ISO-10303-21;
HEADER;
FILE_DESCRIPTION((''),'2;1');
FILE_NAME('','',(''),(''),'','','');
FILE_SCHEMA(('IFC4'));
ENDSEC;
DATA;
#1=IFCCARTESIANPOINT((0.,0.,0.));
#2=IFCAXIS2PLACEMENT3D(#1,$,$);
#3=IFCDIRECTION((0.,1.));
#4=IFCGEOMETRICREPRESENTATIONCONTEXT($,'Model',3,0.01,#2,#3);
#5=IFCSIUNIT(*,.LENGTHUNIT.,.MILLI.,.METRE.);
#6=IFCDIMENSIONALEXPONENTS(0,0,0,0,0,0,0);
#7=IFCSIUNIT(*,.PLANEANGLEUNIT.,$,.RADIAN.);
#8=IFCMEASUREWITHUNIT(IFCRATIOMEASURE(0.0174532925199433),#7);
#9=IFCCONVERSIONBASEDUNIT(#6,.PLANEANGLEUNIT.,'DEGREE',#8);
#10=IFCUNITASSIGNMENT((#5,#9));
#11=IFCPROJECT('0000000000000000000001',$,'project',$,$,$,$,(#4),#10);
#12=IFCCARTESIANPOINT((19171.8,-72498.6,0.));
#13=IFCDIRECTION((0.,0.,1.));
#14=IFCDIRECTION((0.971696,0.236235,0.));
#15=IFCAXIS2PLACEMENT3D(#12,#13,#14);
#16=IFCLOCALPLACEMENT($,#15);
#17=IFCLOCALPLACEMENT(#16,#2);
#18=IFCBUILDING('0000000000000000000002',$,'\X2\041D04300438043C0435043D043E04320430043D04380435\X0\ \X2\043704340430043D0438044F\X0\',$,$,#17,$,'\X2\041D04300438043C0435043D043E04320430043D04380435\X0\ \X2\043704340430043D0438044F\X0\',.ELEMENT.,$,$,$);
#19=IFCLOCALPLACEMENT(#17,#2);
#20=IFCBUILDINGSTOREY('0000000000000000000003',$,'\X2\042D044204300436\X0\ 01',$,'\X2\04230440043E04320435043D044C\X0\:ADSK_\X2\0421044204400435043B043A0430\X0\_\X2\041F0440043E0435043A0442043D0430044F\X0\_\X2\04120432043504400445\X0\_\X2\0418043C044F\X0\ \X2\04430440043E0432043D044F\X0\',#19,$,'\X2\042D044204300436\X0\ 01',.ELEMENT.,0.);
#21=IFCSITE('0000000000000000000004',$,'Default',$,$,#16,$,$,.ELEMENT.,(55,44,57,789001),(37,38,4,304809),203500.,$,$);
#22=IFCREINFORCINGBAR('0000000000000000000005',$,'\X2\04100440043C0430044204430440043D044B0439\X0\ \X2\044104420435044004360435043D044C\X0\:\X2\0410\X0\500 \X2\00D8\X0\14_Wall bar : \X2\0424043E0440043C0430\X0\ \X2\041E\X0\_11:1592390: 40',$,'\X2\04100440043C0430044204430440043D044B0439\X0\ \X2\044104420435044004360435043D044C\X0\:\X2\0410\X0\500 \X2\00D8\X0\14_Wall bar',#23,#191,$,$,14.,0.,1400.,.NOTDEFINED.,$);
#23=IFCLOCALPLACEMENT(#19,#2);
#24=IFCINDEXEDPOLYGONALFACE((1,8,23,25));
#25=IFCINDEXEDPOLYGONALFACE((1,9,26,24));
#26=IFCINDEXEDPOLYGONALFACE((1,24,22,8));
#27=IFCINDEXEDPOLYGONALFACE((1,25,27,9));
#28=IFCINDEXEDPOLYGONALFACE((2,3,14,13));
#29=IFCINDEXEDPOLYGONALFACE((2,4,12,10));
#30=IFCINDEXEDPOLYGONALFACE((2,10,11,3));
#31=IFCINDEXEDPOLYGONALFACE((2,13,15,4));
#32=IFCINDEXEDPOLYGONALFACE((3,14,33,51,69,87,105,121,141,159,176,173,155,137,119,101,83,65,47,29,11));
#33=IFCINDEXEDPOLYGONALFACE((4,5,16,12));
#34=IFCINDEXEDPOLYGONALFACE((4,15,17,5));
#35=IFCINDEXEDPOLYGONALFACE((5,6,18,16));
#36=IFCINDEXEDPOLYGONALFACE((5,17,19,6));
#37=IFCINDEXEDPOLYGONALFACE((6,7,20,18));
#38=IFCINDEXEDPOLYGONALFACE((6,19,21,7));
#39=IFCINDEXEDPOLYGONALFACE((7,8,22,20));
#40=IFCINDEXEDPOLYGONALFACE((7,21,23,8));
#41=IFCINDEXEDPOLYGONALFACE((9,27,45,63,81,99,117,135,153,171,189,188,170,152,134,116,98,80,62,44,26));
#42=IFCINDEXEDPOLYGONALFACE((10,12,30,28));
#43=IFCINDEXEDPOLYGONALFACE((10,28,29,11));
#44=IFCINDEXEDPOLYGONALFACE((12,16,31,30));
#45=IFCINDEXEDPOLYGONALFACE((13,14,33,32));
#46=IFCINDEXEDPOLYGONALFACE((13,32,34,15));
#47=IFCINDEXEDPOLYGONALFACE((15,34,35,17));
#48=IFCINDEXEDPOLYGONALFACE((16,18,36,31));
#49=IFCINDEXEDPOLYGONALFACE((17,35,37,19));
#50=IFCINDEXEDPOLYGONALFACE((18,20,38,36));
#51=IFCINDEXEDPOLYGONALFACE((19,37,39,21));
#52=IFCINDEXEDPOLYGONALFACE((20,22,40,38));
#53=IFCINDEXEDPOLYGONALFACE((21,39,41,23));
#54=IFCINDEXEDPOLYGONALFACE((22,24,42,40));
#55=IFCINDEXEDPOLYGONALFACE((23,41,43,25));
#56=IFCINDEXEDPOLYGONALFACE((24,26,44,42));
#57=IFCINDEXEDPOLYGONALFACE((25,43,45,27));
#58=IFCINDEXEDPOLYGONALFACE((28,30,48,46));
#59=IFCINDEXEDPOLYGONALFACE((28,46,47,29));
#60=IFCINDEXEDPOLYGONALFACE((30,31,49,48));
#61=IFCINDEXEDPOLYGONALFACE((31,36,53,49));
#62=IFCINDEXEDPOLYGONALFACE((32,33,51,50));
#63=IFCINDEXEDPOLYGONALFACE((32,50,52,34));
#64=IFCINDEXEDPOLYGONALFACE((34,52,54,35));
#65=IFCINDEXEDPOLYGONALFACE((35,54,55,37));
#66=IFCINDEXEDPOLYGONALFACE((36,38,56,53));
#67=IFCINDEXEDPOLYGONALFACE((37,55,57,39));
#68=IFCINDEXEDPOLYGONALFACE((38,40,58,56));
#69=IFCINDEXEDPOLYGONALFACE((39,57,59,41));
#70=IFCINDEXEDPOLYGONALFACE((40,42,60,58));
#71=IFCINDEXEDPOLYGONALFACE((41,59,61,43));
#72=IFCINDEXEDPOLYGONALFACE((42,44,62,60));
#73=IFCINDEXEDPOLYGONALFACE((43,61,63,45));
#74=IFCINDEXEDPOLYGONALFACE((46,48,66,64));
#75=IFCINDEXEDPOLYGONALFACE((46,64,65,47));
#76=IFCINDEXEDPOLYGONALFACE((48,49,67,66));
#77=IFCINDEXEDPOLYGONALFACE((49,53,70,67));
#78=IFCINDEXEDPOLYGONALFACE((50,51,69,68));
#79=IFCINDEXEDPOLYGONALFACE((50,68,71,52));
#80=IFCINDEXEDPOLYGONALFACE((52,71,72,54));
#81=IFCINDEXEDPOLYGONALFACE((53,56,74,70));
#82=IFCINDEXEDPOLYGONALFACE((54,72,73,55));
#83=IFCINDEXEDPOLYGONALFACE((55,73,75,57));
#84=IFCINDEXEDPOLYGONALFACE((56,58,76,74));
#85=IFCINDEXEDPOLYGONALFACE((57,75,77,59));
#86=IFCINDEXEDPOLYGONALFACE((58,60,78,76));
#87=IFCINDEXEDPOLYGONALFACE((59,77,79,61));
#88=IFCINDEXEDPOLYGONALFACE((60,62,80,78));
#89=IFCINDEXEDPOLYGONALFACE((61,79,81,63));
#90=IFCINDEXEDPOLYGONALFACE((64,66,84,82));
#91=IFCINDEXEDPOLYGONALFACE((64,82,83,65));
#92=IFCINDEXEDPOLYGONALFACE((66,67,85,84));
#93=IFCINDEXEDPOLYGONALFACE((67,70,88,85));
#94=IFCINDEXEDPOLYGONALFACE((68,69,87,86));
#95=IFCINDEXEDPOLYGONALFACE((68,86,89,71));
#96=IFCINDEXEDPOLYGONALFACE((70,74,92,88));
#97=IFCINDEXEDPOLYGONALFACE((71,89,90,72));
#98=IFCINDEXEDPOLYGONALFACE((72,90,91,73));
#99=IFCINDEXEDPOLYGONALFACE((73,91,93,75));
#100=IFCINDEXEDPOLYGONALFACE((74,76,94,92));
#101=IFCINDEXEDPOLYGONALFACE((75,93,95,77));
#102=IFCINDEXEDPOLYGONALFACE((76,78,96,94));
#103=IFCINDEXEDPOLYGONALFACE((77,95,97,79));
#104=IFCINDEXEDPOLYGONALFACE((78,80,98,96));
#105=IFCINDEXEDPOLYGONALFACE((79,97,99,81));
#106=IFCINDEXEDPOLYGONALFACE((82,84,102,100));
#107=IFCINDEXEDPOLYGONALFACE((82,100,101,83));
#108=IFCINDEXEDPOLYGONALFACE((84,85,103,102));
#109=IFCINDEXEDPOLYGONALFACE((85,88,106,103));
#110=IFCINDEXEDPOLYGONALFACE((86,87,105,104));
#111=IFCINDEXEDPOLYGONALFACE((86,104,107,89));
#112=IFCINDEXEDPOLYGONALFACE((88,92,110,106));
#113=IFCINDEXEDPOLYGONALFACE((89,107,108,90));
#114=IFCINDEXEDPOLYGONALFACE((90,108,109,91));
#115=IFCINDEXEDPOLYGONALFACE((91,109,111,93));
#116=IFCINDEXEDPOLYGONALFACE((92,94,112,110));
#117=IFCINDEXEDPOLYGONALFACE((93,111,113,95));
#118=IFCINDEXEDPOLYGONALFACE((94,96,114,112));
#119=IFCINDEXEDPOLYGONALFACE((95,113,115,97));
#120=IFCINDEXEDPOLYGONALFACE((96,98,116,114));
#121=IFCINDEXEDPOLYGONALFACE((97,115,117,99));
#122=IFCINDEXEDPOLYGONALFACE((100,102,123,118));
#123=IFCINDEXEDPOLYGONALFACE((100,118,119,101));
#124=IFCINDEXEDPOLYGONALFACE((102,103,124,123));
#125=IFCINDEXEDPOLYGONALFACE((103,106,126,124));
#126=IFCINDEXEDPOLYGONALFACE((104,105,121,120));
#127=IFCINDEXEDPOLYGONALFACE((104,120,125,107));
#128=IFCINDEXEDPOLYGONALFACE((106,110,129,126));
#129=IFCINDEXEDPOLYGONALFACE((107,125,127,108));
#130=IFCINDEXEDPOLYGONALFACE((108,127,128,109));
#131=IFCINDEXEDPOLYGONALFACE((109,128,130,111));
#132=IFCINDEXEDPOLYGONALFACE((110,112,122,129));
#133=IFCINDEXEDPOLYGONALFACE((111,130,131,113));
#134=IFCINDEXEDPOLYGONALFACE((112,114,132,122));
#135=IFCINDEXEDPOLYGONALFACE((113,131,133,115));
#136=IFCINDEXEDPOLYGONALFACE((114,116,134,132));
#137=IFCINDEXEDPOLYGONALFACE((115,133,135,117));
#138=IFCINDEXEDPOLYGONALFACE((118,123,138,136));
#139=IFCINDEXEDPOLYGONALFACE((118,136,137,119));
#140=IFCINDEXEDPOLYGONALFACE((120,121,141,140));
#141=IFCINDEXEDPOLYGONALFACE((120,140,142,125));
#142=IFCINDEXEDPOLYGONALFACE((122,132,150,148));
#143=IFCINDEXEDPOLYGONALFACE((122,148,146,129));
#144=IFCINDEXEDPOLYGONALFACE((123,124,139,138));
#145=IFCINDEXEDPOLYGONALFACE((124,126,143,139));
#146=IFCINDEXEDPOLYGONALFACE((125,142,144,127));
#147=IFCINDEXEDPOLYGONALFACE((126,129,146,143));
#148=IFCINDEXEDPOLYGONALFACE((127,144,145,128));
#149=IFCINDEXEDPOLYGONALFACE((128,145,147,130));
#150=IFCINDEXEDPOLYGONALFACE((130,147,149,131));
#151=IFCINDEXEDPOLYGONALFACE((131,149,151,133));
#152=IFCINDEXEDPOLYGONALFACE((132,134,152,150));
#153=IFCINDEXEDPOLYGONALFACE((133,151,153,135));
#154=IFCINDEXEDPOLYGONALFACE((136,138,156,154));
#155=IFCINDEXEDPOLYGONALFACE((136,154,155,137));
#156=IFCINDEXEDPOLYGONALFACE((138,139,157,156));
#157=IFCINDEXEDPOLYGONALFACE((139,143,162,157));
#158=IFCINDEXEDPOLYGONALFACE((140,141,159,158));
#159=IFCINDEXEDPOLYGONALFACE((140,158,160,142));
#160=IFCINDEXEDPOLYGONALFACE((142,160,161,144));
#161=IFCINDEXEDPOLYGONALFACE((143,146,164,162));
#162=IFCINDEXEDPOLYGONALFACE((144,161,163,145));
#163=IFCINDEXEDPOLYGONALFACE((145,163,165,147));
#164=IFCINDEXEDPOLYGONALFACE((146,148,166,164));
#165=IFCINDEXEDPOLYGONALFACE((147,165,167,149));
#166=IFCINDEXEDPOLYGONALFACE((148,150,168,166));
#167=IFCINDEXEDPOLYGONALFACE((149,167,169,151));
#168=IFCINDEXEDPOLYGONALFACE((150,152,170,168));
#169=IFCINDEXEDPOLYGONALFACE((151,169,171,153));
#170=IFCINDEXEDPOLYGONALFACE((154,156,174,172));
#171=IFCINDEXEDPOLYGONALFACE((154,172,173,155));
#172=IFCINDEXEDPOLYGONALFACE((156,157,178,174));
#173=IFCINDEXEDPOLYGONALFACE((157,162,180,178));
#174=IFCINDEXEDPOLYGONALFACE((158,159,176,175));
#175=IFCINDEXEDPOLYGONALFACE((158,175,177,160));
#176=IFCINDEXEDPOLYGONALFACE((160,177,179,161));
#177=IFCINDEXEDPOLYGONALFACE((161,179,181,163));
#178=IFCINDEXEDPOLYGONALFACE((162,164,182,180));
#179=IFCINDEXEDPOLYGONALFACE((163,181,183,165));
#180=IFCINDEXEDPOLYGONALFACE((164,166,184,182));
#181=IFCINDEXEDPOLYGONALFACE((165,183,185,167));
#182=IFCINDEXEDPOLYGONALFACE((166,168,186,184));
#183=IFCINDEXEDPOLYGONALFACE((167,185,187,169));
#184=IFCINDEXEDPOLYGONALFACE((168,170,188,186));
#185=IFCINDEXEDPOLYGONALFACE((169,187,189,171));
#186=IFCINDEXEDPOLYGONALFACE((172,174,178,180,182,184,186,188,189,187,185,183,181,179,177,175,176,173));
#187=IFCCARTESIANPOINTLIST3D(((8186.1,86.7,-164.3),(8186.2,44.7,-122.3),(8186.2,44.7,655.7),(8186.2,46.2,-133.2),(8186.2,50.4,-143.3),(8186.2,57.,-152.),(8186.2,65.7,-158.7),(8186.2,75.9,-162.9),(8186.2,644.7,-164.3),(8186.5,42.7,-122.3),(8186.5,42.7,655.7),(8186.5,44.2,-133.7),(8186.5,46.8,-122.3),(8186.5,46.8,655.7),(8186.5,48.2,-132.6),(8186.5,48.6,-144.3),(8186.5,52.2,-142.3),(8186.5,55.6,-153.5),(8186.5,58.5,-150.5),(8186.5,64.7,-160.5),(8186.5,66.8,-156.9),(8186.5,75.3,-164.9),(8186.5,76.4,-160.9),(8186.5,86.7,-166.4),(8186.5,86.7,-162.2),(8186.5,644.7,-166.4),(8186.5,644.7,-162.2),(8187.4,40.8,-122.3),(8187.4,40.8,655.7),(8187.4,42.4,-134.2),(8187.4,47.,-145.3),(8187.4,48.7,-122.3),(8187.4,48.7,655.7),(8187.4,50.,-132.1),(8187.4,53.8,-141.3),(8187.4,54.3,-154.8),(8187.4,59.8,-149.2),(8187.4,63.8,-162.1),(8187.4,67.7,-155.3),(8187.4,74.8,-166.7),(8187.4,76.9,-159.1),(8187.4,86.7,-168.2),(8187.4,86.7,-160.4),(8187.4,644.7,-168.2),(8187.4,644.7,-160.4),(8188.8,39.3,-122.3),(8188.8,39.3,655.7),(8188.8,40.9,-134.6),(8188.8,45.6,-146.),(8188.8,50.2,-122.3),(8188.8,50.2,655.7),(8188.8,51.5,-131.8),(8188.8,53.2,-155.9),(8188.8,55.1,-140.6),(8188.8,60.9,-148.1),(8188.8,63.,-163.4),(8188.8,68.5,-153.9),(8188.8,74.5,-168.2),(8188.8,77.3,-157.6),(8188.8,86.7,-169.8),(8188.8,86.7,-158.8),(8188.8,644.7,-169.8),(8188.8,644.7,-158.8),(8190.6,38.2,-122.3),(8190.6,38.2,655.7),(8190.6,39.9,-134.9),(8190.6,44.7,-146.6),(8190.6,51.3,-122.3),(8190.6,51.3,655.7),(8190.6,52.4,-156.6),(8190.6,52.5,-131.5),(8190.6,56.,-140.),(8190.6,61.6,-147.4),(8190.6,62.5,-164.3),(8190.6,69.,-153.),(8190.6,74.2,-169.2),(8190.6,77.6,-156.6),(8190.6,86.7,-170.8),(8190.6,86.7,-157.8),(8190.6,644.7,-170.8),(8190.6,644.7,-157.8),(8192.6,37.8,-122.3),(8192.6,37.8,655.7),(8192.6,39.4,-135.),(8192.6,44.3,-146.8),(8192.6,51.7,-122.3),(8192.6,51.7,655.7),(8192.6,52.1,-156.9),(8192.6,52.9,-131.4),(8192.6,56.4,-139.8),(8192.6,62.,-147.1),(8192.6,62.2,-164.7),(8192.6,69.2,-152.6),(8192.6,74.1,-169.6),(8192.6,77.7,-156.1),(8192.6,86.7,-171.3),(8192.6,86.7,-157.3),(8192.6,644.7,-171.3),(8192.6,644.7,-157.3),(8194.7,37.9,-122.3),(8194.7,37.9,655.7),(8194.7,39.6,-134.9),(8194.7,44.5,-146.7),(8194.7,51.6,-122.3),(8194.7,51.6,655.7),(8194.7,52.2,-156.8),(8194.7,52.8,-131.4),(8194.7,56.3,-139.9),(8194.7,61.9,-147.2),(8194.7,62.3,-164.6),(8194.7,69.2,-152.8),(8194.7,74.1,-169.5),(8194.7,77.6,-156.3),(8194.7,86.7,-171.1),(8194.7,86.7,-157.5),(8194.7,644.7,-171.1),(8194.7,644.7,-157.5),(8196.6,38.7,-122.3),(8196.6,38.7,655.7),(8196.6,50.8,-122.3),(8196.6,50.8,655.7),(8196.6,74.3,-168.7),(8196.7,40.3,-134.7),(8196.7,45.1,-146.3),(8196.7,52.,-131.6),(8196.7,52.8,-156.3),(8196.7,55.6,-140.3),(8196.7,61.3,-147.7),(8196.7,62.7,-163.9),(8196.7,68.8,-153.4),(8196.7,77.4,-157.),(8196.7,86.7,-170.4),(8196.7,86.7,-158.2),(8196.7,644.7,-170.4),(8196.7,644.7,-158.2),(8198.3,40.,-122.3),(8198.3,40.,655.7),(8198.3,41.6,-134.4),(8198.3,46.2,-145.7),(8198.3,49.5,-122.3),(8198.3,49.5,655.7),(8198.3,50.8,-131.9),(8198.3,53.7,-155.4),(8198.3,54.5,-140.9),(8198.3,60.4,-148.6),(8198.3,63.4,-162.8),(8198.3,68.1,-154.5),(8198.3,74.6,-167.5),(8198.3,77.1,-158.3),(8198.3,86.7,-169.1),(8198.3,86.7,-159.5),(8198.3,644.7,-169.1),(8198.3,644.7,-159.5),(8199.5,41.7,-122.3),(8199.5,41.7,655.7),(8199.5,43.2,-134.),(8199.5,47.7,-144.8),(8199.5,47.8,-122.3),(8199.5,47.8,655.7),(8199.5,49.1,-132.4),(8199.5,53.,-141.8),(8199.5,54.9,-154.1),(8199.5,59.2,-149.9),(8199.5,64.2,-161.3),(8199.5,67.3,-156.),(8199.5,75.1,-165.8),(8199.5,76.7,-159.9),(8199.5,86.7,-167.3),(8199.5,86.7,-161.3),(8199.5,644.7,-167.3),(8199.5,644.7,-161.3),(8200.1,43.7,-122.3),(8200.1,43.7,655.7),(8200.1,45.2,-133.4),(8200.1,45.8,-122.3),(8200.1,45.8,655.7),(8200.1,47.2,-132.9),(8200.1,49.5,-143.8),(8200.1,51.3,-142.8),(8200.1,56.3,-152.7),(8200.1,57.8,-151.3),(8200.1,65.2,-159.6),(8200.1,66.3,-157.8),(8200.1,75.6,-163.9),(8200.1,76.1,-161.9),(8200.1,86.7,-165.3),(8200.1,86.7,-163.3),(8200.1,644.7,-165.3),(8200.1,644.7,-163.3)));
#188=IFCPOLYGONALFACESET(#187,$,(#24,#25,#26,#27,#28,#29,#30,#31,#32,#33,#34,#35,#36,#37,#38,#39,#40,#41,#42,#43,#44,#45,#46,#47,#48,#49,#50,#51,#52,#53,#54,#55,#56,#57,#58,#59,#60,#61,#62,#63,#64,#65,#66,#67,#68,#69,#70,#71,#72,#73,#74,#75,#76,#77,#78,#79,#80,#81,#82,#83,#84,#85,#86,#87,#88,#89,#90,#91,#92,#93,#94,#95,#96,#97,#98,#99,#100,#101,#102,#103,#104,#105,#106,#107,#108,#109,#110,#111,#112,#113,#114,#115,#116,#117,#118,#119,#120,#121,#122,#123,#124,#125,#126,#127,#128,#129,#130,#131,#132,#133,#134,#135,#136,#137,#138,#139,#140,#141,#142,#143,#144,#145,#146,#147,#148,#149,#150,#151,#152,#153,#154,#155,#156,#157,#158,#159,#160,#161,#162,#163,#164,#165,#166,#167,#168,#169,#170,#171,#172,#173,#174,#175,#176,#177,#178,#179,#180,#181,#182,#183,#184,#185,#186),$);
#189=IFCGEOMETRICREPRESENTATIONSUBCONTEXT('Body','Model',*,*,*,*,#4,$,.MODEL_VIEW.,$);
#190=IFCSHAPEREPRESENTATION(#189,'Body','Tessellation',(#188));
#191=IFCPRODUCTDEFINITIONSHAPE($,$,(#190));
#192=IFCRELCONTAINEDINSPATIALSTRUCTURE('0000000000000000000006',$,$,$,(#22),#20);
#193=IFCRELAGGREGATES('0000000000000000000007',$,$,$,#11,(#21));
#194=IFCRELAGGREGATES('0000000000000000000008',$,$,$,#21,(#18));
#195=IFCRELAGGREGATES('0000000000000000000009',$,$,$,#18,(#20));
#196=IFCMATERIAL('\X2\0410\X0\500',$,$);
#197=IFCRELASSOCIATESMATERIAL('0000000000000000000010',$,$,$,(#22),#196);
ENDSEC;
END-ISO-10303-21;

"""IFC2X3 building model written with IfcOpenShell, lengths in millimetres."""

from ifc_helpers import new_model, entity, si_unit, converted_unit, direction, frame, origin, place, context, subcontext, project, spatial, material, element, save


model = new_model("IFC2X3")

# Units and contexts
model_context = context("Model", 3, precision=0.01, world=origin(), true_north=direction((0.0, 1.0)))
body_context = subcontext(model_context, "Body", "Model", "MODEL_VIEW")
ifc_project = project(units=[si_unit("LENGTHUNIT", "METRE", prefix="MILLI"), converted_unit("PLANEANGLEUNIT", "DEGREE", entity("IfcRatioMeasure", 0.0174532925199433), si_unit("PLANEANGLEUNIT", "RADIAN"), dimensions=[0, 0, 0, 0, 0, 0, 0])], contexts=[model_context])

# Site, building, storey
site_placement = place(None, frame((19171.8, -72498.6, 0.0), z_axis=(0.0, 0.0, 1.0), x_axis=(0.971696, 0.236235, 0.0)))
site = spatial("IfcSite", under=ifc_project, at=site_placement, Name="Default", CompositionType="ELEMENT", RefLatitude=(55, 44, 57, 789001), RefLongitude=(37, 38, 4, 304809), RefElevation=203500.0)
building_placement = place(site_placement, origin())
building = spatial("IfcBuilding", under=site, at=building_placement, Name="Наименование здания", LongName="Наименование здания", CompositionType="ELEMENT")
storey_placement = place(building_placement, origin())
storey = spatial("IfcBuildingStorey", under=building, at=storey_placement, Name="Этаж 01", ObjectType="Уровень:ADSK_Стрелка_Проектная_Вверх_Имя уровня", LongName="Этаж 01", CompositionType="ELEMENT", Elevation=0.0)

# Reinforcing bar
ifc_material = material(Name="А500")
placement = place(storey_placement, origin())
element("IfcReinforcingBar", 1, at=placement, inside=storey, material=ifc_material, Name="Арматурный стержень:А500 Ø14_Wall bar : Форма О_11:1592390: 40", ObjectType="Арматурный стержень:А500 Ø14_Wall bar", BarLength=1400.0, BarRole="NOTDEFINED", CrossSectionArea=0.0, NominalDiameter=14.0, context=body_context, shape_type="AdvancedSweptSolid", body=[
    entity("IfcSweptDiskSolid", entity("IfcCompositeCurve", [entity("IfcCompositeCurveSegment", "CONTINUOUS", True, entity("IfcPolyline", [entity("IfcCartesianPoint", [8193.1, 44.7, 655.7]), entity("IfcCartesianPoint", [8193.1, 44.7, -122.3])])), entity("IfcCompositeCurveSegment", "CONTINUOUS", True, entity("IfcTrimmedCurve", entity("IfcCircle", entity("IfcAxis2Placement3D", entity("IfcCartesianPoint", [8193.1, 86.7, -122.3]), entity("IfcDirection", [1.0, 0.0, 0.0]), entity("IfcDirection", [0.0, 0.0, -1.0])), 42.0), [entity("IfcParameterValue", 270.0)], [entity("IfcParameterValue", 360.0)], True, "PARAMETER")), entity("IfcCompositeCurveSegment", "CONTINUOUS", True, entity("IfcPolyline", [entity("IfcCartesianPoint", [8193.1, 86.7, -164.3]), entity("IfcCartesianPoint", [8193.1, 644.7, -164.3])]))], False), 7.0, None, 0.0, 92.0),
])

save(model, "model.ifc")
